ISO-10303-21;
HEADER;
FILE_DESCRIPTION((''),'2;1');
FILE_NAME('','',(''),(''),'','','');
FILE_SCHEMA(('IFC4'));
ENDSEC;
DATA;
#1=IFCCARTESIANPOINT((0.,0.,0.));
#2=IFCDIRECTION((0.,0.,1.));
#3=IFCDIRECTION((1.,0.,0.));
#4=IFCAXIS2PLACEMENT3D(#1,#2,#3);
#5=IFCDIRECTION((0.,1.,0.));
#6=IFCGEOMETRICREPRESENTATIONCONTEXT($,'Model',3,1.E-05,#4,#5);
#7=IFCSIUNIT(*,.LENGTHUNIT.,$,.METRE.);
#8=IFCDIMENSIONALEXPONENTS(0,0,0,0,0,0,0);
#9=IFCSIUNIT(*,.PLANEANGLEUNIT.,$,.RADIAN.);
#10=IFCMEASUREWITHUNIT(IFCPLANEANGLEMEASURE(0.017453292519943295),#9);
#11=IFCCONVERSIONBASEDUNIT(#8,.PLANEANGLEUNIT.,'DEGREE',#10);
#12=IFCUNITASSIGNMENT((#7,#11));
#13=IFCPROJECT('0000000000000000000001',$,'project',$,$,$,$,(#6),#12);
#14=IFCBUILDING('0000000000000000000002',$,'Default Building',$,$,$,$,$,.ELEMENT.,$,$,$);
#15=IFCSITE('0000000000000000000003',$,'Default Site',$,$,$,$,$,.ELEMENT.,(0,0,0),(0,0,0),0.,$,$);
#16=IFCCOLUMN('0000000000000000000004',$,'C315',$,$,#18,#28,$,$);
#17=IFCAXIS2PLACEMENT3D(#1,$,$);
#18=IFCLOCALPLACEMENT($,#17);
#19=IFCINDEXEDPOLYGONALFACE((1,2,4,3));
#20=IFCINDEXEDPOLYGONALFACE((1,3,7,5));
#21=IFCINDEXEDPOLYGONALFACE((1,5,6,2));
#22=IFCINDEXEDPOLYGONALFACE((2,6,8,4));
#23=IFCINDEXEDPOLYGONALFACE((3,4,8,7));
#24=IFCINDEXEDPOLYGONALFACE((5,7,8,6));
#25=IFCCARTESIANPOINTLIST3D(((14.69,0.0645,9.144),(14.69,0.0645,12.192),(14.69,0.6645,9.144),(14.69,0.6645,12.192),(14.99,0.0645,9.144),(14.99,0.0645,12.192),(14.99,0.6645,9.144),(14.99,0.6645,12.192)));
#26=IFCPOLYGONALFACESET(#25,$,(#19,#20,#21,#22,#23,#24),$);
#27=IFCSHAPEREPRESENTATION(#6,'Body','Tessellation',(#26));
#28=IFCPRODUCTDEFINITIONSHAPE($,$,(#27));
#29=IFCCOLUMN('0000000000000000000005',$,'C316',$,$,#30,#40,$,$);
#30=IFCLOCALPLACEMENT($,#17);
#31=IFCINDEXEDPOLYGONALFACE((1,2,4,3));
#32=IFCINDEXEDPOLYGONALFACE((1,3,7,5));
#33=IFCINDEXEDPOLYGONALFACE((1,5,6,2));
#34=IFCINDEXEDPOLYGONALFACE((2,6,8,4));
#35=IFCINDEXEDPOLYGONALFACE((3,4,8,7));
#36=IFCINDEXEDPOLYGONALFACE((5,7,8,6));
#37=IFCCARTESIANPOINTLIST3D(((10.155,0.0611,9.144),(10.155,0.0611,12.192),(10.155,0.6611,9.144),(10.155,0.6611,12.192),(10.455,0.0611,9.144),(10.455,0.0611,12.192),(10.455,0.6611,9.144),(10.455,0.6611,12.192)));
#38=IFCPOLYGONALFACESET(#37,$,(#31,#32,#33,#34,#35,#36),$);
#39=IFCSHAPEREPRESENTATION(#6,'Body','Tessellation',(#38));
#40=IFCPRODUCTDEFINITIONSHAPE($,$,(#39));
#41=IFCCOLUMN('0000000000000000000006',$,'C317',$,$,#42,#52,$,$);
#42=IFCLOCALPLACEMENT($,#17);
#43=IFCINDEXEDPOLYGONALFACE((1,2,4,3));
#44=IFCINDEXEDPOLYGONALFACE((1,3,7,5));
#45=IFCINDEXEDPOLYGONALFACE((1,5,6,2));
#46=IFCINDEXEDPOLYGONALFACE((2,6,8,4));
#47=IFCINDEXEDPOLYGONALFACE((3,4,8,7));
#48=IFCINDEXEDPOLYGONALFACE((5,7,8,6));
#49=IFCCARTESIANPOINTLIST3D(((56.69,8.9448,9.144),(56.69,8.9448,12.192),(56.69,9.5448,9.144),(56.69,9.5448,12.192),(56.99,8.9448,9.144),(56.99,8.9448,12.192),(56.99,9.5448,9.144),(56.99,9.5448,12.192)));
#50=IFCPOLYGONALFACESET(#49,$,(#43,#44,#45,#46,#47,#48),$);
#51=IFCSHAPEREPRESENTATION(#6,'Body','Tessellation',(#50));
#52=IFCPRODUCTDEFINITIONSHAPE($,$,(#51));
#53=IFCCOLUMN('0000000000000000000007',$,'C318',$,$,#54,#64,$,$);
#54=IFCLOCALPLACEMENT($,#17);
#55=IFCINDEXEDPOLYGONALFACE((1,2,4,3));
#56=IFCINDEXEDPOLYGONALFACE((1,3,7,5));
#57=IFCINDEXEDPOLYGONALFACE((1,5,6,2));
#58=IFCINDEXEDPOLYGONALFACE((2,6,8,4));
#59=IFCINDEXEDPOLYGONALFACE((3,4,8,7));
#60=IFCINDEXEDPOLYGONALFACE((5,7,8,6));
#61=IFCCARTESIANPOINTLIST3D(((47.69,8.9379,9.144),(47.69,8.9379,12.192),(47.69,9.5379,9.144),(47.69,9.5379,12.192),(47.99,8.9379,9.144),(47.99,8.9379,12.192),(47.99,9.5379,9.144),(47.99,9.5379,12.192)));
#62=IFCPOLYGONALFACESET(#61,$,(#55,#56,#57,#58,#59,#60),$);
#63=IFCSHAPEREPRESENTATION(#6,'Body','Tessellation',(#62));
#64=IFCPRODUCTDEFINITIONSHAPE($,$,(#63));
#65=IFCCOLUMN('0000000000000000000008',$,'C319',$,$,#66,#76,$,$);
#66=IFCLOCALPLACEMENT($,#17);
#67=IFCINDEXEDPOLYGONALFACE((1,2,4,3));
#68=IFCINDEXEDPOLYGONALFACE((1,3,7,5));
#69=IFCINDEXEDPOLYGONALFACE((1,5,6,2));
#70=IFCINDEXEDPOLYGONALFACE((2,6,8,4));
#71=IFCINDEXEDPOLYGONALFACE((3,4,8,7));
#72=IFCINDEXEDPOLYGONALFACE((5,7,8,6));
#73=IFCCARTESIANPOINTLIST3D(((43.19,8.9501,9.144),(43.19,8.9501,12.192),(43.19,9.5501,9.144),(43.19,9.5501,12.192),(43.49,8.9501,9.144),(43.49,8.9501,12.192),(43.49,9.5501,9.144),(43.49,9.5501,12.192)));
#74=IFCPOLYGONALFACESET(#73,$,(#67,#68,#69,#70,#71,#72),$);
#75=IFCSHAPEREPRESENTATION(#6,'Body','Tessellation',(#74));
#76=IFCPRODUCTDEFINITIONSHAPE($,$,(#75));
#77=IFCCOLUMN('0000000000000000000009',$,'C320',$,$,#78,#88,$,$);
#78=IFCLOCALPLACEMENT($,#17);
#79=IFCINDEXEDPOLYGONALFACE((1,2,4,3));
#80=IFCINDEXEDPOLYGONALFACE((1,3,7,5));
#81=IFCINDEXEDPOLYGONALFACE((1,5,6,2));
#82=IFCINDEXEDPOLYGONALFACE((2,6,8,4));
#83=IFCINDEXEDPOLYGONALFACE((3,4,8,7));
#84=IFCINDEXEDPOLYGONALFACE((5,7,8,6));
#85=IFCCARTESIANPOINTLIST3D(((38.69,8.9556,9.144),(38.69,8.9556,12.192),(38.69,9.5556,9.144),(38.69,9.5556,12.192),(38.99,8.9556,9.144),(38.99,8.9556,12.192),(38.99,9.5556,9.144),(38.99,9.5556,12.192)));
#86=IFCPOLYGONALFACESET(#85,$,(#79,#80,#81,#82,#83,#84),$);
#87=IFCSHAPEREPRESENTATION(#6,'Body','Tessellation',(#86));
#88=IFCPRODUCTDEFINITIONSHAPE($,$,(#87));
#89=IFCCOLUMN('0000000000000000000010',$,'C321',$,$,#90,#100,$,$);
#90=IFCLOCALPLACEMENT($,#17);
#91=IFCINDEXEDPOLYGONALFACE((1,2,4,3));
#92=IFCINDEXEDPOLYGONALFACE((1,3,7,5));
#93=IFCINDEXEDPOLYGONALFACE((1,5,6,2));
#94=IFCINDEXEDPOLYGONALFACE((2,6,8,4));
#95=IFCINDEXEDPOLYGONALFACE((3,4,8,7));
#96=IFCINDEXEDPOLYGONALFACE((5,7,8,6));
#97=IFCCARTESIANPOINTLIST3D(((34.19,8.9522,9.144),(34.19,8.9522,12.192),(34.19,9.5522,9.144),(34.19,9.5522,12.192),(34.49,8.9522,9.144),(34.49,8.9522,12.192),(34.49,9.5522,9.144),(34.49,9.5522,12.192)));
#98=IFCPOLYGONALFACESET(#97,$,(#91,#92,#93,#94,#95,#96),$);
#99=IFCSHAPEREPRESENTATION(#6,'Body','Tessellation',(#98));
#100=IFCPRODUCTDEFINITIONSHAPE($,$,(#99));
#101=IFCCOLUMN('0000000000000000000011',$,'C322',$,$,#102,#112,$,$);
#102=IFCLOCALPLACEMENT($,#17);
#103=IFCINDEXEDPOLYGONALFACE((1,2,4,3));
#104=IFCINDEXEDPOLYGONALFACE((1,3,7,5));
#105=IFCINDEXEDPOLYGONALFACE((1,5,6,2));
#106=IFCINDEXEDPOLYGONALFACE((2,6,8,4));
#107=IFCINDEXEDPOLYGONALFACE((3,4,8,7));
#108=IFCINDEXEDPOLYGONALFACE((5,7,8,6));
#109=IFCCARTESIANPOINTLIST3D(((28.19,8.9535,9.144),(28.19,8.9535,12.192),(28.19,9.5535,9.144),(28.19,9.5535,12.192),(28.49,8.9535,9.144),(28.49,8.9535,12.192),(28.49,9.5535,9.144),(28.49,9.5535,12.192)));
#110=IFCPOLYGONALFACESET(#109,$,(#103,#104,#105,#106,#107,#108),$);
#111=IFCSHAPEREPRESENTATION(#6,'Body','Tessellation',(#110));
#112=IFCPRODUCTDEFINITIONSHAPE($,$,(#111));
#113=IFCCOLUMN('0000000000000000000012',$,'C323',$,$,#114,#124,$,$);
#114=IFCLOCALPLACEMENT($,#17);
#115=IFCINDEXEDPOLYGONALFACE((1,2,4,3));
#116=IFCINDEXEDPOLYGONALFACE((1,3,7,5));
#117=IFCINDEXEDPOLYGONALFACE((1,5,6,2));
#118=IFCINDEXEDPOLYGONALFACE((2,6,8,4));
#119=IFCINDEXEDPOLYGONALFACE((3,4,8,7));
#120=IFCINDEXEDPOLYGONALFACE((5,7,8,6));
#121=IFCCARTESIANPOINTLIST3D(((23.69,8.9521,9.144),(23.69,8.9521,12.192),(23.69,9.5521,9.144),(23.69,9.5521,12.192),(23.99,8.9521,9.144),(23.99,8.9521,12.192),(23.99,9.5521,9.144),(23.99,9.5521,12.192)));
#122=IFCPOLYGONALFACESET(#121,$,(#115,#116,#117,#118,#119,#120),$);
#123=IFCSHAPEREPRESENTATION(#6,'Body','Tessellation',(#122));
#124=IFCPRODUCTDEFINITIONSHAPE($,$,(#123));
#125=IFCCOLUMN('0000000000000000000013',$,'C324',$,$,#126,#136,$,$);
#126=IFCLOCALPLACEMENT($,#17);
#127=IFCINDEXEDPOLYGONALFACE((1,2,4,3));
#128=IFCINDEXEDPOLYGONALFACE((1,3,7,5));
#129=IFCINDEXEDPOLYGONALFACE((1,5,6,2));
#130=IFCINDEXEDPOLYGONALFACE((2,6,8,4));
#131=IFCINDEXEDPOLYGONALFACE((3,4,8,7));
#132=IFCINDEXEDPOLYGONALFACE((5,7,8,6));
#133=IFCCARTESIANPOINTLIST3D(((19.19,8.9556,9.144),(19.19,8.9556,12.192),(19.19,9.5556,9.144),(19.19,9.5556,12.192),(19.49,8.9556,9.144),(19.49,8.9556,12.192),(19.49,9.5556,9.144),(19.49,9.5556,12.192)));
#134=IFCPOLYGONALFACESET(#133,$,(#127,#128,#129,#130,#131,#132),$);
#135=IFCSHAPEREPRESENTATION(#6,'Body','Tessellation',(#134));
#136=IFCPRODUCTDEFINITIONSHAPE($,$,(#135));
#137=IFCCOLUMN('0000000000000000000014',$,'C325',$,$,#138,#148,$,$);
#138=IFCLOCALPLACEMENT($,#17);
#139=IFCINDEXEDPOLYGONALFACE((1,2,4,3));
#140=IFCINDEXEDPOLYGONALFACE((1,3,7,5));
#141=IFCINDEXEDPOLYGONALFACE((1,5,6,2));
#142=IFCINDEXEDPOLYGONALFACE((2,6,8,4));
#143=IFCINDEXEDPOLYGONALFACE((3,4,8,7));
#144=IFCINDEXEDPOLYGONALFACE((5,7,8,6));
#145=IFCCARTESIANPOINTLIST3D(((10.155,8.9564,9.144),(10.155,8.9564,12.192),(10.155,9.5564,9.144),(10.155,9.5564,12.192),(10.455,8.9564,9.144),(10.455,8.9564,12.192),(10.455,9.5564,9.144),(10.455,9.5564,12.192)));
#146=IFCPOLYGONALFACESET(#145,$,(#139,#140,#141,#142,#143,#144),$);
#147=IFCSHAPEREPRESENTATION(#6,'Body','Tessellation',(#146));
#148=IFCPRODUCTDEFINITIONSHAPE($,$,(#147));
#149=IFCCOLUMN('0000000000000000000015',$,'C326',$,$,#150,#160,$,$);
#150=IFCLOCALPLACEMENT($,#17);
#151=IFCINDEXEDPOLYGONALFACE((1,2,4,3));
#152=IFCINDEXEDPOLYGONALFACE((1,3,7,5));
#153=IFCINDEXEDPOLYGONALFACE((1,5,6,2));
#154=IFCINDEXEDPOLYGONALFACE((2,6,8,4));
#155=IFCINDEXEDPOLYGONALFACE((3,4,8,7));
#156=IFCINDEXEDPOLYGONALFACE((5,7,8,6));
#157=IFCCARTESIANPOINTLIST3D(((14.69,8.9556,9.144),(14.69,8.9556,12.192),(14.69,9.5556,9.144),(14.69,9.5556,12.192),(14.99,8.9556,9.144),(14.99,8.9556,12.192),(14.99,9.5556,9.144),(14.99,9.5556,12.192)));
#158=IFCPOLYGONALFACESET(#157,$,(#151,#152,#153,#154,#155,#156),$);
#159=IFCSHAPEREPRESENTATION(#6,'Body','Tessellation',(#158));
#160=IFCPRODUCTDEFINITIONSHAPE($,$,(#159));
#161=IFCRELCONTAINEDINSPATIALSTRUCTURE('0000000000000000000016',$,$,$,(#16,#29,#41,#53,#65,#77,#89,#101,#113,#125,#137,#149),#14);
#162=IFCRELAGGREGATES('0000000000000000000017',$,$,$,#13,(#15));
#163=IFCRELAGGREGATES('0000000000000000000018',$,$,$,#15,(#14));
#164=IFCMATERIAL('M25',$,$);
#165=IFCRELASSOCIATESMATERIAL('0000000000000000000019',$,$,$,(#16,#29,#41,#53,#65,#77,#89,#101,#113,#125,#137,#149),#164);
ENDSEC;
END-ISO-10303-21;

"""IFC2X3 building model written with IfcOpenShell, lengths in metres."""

from ifc_helpers import new_model, entity, si_unit, converted_unit, direction, frame, frame_2d, origin_with_axes, place, context, project, spatial, rectangle, extrude, material, element, save


model = new_model("IFC2X3")

# Units and contexts
model_context = context("Model", 3, precision=1e-05, world=origin_with_axes(), true_north=direction((0.0, 1.0, 0.0)))
ifc_project = project(units=[si_unit("LENGTHUNIT", "METRE"), converted_unit("PLANEANGLEUNIT", "DEGREE", entity("IfcPlaneAngleMeasure", 0.017453292519943295), si_unit("PLANEANGLEUNIT", "RADIAN"), dimensions=[0, 0, 0, 0, 0, 0, 0])], contexts=[model_context])

# Site, building
site = spatial("IfcSite", under=ifc_project, Name="Default Site", CompositionType="ELEMENT", RefLatitude=(0, 0, 0), RefLongitude=(0, 0, 0), RefElevation=0.0)
building = spatial("IfcBuilding", under=site, Name="Default Building", CompositionType="ELEMENT")

# Columns
ifc_material = material(Name="M25")
placement = place(None, origin_with_axes())
element("IfcColumn", 1, at=placement, inside=building, material=ifc_material, Name="C315", context=model_context, shape_type="SweptSolid", body=[
    extrude(rectangle(XDim=0.3, YDim=0.6, at=frame_2d((0.0, 0.0), x_axis=(1.0, 0.0, 0.0))), frame((14.84, 0.3645, 9.144), z_axis=(0.0, 0.0, 1.0), x_axis=(1.0, 0.0, 0.0)), (0.0, 0.0, 1.0), 3.048),
])
element("IfcColumn", 2, at=placement, inside=building, material=ifc_material, Name="C316", context=model_context, shape_type="SweptSolid", body=[
    extrude(rectangle(XDim=0.3, YDim=0.6, at=frame_2d((0.0, 0.0), x_axis=(1.0, 0.0, 0.0))), frame((10.305, 0.3611, 9.144), z_axis=(0.0, 0.0, 1.0), x_axis=(1.0, 0.0, 0.0)), (0.0, 0.0, 1.0), 3.048),
])
element("IfcColumn", 3, at=placement, inside=building, material=ifc_material, Name="C317", context=model_context, shape_type="SweptSolid", body=[
    extrude(rectangle(XDim=0.3, YDim=0.6, at=frame_2d((0.0, 0.0), x_axis=(1.0, 0.0, 0.0))), frame((56.84, 9.2448, 9.144), z_axis=(0.0, 0.0, 1.0), x_axis=(1.0, 0.0, 0.0)), (0.0, 0.0, 1.0), 3.048),
])
element("IfcColumn", 4, at=placement, inside=building, material=ifc_material, Name="C318", context=model_context, shape_type="SweptSolid", body=[
    extrude(rectangle(XDim=0.3, YDim=0.6, at=frame_2d((0.0, 0.0), x_axis=(1.0, 0.0, 0.0))), frame((47.84, 9.2379, 9.144), z_axis=(0.0, 0.0, 1.0), x_axis=(1.0, 0.0, 0.0)), (0.0, 0.0, 1.0), 3.048),
])
element("IfcColumn", 5, at=placement, inside=building, material=ifc_material, Name="C319", context=model_context, shape_type="SweptSolid", body=[
    extrude(rectangle(XDim=0.3, YDim=0.6, at=frame_2d((0.0, 0.0), x_axis=(1.0, 0.0, 0.0))), frame((43.34, 9.2501, 9.144), z_axis=(0.0, 0.0, 1.0), x_axis=(1.0, 0.0, 0.0)), (0.0, 0.0, 1.0), 3.048),
])
element("IfcColumn", 6, at=placement, inside=building, material=ifc_material, Name="C320", context=model_context, shape_type="SweptSolid", body=[
    extrude(rectangle(XDim=0.3, YDim=0.6, at=frame_2d((0.0, 0.0), x_axis=(1.0, 0.0, 0.0))), frame((38.84, 9.2556, 9.144), z_axis=(0.0, 0.0, 1.0), x_axis=(1.0, 0.0, 0.0)), (0.0, 0.0, 1.0), 3.048),
])
element("IfcColumn", 7, at=placement, inside=building, material=ifc_material, Name="C321", context=model_context, shape_type="SweptSolid", body=[
    extrude(rectangle(XDim=0.3, YDim=0.6, at=frame_2d((0.0, 0.0), x_axis=(1.0, 0.0, 0.0))), frame((34.34, 9.2522, 9.144), z_axis=(0.0, 0.0, 1.0), x_axis=(1.0, 0.0, 0.0)), (0.0, 0.0, 1.0), 3.048),
])
element("IfcColumn", 8, at=placement, inside=building, material=ifc_material, Name="C322", context=model_context, shape_type="SweptSolid", body=[
    extrude(rectangle(XDim=0.3, YDim=0.6, at=frame_2d((0.0, 0.0), x_axis=(1.0, 0.0, 0.0))), frame((28.34, 9.2535, 9.144), z_axis=(0.0, 0.0, 1.0), x_axis=(1.0, 0.0, 0.0)), (0.0, 0.0, 1.0), 3.048),
])
element("IfcColumn", 9, at=placement, inside=building, material=ifc_material, Name="C323", context=model_context, shape_type="SweptSolid", body=[
    extrude(rectangle(XDim=0.3, YDim=0.6, at=frame_2d((0.0, 0.0), x_axis=(1.0, 0.0, 0.0))), frame((23.84, 9.2521, 9.144), z_axis=(0.0, 0.0, 1.0), x_axis=(1.0, 0.0, 0.0)), (0.0, 0.0, 1.0), 3.048),
])
element("IfcColumn", 10, at=placement, inside=building, material=ifc_material, Name="C324", context=model_context, shape_type="SweptSolid", body=[
    extrude(rectangle(XDim=0.3, YDim=0.6, at=frame_2d((0.0, 0.0), x_axis=(1.0, 0.0, 0.0))), frame((19.34, 9.2556, 9.144), z_axis=(0.0, 0.0, 1.0), x_axis=(1.0, 0.0, 0.0)), (0.0, 0.0, 1.0), 3.048),
])
element("IfcColumn", 11, at=placement, inside=building, material=ifc_material, Name="C325", context=model_context, shape_type="SweptSolid", body=[
    extrude(rectangle(XDim=0.3, YDim=0.6, at=frame_2d((0.0, 0.0), x_axis=(1.0, 0.0, 0.0))), frame((10.305, 9.2564, 9.144), z_axis=(0.0, 0.0, 1.0), x_axis=(1.0, 0.0, 0.0)), (0.0, 0.0, 1.0), 3.048),
])
element("IfcColumn", 12, at=placement, inside=building, material=ifc_material, Name="C326", context=model_context, shape_type="SweptSolid", body=[
    extrude(rectangle(XDim=0.3, YDim=0.6, at=frame_2d((0.0, 0.0), x_axis=(1.0, 0.0, 0.0))), frame((14.84, 9.2556, 9.144), z_axis=(0.0, 0.0, 1.0), x_axis=(1.0, 0.0, 0.0)), (0.0, 0.0, 1.0), 3.048),
])

save(model, "model.ifc")
